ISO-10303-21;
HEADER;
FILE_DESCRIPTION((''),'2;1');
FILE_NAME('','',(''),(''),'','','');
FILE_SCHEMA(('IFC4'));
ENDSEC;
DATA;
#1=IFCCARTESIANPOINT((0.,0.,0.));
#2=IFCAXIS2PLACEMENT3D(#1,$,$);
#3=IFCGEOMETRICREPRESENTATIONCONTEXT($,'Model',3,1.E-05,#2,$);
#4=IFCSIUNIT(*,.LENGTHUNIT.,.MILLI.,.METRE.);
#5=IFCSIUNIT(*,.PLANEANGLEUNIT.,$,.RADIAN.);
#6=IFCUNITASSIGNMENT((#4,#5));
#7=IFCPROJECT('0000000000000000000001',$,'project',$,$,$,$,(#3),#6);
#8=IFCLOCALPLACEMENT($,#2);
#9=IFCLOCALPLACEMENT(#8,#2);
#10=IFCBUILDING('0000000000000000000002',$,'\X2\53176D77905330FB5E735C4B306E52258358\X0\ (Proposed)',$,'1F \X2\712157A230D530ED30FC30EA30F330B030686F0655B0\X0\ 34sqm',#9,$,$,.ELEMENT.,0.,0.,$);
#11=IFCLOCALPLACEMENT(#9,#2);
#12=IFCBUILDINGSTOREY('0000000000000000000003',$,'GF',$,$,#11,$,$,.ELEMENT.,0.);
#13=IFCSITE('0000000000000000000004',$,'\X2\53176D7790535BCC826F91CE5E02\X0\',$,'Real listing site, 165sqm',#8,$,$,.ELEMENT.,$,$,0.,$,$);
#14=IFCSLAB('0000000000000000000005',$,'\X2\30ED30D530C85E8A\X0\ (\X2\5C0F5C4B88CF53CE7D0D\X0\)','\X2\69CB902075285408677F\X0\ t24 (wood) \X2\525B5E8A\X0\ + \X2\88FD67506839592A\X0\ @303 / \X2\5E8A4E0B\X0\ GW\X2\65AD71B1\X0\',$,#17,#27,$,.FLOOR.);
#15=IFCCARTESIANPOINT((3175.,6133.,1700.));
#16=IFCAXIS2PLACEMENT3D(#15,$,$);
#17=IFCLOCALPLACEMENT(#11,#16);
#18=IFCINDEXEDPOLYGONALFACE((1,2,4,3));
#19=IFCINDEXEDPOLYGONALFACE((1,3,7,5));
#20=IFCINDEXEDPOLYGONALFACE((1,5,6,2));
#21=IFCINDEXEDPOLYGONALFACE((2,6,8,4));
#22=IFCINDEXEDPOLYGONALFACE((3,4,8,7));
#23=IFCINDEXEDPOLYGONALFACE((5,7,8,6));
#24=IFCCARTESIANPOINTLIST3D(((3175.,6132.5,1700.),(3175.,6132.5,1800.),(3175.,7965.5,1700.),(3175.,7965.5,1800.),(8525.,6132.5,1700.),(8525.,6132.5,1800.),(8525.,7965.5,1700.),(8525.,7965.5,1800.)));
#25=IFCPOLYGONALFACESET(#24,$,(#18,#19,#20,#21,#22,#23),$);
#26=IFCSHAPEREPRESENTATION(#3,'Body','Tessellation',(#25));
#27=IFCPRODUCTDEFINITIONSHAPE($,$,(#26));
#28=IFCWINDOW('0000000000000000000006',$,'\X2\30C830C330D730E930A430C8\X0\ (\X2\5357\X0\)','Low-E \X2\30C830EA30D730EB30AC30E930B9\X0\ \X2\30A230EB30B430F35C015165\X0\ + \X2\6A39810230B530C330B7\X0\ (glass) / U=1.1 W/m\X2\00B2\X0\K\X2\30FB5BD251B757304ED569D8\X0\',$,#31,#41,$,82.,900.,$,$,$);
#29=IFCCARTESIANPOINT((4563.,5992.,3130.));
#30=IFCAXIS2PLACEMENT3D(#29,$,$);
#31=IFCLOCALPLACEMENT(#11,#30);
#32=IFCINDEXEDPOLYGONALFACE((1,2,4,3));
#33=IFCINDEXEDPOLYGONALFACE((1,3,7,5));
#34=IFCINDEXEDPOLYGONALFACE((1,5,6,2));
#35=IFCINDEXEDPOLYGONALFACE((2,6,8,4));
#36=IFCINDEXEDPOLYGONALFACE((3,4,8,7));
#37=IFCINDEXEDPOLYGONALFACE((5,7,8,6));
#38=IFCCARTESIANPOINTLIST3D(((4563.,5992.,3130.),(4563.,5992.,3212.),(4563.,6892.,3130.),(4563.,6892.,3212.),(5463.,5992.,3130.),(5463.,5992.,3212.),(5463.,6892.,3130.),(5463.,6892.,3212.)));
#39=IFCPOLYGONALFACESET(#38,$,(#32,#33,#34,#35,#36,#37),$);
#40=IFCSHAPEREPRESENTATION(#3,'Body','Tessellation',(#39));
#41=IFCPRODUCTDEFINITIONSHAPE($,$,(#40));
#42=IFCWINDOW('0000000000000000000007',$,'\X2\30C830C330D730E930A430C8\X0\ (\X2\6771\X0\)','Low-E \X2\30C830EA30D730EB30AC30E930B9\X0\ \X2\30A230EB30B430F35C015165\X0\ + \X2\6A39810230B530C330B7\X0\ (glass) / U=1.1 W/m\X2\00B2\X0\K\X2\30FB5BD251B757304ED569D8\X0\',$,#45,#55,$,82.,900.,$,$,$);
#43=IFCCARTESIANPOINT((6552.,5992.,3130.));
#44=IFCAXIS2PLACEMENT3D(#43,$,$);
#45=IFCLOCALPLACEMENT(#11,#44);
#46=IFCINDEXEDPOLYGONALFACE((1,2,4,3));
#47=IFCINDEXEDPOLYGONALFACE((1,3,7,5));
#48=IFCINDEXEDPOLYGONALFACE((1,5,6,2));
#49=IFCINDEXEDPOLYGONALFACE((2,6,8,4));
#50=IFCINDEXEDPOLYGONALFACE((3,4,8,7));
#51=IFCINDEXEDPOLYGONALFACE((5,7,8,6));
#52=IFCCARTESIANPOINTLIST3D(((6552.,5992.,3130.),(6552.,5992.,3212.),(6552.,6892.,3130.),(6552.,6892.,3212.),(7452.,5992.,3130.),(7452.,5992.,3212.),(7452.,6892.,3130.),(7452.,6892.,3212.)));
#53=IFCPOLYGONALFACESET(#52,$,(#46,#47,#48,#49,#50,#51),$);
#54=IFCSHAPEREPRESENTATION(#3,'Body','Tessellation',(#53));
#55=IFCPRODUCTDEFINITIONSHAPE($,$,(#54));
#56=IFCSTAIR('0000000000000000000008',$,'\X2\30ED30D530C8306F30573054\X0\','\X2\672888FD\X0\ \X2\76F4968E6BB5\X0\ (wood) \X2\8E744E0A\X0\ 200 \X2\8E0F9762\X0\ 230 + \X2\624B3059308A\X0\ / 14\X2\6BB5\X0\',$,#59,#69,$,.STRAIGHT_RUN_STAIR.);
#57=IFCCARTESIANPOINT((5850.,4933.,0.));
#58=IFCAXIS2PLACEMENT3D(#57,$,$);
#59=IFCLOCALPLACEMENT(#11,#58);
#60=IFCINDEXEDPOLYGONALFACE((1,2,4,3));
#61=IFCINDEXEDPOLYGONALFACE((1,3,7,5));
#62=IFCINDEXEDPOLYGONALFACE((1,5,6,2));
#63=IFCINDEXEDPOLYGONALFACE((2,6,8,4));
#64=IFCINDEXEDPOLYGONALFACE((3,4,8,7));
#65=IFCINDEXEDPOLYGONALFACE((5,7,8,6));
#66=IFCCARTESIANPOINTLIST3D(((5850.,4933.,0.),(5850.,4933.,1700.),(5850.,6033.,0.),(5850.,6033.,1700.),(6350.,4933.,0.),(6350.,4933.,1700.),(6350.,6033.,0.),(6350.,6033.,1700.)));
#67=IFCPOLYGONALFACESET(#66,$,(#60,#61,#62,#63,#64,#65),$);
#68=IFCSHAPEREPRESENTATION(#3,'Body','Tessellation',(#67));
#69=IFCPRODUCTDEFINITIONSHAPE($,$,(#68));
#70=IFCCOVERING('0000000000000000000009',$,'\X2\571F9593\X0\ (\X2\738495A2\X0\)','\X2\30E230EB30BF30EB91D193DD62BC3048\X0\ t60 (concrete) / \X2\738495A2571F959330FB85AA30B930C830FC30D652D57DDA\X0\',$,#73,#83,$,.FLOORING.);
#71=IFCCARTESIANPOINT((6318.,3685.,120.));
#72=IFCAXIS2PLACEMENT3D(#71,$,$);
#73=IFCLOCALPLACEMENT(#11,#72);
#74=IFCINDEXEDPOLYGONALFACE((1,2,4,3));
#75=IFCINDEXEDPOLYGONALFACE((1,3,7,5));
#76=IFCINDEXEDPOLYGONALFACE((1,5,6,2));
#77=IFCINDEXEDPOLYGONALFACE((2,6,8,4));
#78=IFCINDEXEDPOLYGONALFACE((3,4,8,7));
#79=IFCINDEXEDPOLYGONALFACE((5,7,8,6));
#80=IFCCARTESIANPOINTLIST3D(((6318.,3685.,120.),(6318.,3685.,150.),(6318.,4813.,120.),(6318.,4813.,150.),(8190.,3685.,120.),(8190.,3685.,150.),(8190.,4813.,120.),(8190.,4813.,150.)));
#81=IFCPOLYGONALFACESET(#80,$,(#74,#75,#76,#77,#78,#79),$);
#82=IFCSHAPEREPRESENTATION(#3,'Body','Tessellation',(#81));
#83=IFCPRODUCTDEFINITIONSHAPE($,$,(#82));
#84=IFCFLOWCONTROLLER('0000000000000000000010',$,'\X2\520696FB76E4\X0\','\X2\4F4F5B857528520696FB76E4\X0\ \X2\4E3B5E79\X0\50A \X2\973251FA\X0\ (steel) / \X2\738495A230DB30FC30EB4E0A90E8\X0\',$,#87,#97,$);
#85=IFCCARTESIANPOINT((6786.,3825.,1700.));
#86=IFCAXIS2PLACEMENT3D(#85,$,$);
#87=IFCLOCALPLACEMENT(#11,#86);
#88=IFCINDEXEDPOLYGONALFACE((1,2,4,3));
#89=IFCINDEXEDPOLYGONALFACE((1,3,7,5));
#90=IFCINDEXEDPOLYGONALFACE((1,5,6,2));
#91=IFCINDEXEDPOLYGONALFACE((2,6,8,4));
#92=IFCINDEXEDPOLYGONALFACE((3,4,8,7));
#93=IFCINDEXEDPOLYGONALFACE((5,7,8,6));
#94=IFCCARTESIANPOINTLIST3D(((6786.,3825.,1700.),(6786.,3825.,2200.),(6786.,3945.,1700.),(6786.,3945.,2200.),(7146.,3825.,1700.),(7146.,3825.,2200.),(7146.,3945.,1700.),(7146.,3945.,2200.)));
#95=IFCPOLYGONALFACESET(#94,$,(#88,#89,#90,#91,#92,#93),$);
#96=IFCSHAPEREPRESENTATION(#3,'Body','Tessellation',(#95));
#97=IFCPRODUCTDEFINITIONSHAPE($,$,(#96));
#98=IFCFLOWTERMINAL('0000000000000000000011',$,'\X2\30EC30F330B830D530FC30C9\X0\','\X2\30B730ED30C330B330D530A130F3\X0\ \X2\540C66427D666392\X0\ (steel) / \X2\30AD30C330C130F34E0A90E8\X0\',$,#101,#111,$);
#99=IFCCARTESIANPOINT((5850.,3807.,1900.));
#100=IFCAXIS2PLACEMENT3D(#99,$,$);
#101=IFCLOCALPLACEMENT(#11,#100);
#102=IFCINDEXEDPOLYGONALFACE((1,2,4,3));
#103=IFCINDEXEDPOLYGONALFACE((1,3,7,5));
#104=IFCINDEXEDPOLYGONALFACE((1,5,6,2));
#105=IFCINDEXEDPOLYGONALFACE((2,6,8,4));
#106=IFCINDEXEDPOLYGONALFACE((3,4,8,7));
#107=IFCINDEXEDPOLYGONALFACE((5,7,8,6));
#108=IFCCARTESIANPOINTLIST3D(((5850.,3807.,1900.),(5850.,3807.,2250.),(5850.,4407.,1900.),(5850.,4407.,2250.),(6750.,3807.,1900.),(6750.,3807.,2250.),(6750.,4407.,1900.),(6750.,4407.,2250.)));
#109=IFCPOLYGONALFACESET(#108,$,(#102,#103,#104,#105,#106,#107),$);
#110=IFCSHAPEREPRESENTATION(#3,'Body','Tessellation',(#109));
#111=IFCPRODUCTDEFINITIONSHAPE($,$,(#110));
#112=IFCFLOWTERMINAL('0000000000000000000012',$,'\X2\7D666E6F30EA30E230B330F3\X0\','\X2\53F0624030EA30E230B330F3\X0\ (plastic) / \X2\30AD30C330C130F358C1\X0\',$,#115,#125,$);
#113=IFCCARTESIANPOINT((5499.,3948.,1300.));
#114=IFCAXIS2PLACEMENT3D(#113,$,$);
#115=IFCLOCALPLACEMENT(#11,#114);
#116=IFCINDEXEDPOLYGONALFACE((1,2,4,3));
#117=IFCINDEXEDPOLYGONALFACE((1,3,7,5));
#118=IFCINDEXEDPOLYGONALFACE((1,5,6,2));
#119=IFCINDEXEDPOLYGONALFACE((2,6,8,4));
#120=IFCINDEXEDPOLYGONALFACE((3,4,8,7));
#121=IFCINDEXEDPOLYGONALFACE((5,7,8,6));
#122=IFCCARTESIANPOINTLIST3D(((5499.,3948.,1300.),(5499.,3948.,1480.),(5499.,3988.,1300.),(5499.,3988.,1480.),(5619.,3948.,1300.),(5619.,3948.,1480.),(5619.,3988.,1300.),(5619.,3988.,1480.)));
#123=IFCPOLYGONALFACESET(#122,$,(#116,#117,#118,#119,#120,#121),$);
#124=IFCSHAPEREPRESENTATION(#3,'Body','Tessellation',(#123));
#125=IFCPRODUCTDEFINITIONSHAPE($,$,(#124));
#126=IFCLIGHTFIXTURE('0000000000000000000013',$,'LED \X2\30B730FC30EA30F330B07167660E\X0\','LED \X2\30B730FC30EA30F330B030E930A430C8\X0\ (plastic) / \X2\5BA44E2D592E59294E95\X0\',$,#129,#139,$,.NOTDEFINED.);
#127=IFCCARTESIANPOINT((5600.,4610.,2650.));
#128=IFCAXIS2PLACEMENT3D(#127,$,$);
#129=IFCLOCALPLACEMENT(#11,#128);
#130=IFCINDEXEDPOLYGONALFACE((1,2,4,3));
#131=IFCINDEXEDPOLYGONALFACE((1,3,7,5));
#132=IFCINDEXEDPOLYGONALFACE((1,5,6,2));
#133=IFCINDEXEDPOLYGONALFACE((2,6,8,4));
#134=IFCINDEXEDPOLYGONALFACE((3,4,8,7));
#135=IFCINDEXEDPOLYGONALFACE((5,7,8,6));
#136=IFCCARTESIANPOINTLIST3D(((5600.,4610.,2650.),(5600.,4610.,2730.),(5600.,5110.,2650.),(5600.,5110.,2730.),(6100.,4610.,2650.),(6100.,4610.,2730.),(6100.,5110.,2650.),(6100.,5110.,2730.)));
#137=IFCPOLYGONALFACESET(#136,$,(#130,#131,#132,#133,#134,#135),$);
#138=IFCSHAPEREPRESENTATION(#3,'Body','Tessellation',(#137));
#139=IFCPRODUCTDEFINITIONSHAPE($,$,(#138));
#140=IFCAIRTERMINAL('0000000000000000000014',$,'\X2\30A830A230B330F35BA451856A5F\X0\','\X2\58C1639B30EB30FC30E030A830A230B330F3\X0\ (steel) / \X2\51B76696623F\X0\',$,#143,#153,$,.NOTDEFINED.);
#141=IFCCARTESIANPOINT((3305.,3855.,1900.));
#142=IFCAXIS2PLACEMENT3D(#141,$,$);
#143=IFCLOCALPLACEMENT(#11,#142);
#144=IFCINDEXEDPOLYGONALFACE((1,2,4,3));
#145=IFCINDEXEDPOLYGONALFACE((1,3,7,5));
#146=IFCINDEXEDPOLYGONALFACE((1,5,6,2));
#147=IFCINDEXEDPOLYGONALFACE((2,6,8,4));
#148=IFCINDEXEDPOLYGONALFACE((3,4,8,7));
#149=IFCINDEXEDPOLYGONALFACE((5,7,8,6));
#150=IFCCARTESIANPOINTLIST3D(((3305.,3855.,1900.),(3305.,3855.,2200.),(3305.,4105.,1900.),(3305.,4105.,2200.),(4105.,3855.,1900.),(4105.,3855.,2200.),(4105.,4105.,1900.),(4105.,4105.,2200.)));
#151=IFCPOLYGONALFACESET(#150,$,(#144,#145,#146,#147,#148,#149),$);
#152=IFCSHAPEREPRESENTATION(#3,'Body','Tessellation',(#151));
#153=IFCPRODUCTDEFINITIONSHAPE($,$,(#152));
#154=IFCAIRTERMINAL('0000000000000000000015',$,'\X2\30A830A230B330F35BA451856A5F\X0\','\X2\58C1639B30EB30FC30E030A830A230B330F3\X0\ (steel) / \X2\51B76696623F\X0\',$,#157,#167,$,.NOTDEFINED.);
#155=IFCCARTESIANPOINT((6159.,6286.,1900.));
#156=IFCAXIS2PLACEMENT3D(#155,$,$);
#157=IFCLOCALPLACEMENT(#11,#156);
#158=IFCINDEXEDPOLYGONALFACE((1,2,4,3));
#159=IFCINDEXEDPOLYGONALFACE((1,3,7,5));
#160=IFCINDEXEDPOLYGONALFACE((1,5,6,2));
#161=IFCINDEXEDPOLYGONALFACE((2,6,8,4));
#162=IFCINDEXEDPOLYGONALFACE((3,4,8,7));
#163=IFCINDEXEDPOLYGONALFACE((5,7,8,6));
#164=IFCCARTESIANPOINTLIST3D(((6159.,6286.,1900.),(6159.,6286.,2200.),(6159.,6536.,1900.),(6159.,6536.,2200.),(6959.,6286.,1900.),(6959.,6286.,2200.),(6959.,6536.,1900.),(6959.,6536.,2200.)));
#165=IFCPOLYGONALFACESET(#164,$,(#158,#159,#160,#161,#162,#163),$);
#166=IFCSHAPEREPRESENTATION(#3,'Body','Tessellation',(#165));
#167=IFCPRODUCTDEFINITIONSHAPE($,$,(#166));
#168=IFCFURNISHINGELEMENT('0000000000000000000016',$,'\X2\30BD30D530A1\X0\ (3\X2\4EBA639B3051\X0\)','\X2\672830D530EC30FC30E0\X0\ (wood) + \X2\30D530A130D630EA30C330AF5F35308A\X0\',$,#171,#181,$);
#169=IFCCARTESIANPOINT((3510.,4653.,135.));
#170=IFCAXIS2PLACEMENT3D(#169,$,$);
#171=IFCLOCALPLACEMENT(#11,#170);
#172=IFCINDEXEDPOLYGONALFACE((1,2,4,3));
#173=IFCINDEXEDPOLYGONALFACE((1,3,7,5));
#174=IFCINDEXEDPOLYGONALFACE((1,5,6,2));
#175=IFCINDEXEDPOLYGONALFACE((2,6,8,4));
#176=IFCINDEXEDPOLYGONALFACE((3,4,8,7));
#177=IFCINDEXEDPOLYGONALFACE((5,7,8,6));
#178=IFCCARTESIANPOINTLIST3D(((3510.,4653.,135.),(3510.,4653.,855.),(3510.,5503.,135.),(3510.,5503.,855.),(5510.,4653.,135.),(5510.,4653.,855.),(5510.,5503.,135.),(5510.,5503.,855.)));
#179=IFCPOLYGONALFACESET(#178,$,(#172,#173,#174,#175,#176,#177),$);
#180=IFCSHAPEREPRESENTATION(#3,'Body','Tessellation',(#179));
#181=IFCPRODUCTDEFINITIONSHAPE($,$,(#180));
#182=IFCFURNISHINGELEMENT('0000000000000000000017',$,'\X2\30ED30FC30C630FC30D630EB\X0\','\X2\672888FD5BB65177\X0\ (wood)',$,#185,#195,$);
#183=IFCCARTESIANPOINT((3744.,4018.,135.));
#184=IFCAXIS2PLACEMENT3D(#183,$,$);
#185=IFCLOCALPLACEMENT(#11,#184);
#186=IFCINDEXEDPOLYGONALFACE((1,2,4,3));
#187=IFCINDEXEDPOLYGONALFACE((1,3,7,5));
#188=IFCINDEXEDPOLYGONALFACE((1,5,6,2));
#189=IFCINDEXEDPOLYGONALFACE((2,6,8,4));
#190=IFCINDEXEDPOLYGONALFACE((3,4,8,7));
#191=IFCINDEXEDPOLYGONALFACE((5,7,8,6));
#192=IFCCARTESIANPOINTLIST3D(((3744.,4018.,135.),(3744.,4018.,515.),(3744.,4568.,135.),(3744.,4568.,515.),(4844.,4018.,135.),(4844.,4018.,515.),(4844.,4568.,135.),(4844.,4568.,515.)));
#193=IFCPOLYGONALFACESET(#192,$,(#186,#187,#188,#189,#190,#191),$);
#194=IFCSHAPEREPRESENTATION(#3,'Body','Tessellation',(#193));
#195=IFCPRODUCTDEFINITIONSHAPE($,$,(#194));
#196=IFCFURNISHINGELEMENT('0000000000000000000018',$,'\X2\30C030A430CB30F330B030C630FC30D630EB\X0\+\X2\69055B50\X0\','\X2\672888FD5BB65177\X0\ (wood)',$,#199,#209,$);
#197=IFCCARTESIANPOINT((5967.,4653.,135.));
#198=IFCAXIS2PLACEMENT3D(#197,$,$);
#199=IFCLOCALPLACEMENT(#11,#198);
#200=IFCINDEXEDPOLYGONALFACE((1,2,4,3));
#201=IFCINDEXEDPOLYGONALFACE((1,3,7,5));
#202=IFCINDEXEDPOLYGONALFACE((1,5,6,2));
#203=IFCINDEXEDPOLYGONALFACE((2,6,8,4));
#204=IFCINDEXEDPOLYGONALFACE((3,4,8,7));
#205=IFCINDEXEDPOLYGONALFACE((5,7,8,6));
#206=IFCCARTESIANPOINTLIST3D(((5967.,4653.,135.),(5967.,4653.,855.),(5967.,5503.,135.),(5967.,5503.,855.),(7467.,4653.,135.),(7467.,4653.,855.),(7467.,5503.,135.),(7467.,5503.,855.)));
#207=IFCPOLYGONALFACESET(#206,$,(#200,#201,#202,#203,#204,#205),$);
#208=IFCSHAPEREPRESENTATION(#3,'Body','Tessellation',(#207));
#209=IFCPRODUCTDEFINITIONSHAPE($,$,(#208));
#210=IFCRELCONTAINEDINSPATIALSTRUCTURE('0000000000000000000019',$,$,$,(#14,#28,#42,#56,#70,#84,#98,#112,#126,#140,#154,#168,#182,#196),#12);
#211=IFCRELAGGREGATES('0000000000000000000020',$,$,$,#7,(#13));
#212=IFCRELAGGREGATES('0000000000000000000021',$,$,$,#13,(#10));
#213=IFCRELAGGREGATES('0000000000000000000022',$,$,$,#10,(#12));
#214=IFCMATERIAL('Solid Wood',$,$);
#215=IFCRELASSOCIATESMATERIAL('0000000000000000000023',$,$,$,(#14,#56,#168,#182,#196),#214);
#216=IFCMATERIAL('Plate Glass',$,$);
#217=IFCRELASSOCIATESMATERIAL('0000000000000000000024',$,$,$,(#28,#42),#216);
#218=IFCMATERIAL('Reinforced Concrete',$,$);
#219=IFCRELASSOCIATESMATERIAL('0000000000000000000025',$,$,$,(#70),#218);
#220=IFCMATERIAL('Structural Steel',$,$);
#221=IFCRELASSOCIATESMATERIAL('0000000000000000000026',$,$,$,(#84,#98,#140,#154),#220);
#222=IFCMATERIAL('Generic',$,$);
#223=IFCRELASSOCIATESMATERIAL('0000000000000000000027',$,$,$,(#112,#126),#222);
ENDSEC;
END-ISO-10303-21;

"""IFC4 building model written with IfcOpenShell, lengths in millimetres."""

from ifc_helpers import new_model, si_unit, frame, frame_2d, origin, place, context, project, spatial, rectangle, extrude, material, element, save


model = new_model("IFC4")

# Units and contexts
model_context = context("Model", 3, precision=1e-05, world=origin())
ifc_project = project(units=[si_unit("LENGTHUNIT", "METRE", prefix="MILLI"), si_unit("PLANEANGLEUNIT", "RADIAN")], contexts=[model_context])

# Site, building, storey
site_placement = place(None, origin())
site = spatial("IfcSite", under=ifc_project, at=site_placement, Name="北海道富良野市", ObjectType="Real listing site, 165sqm", CompositionType="ELEMENT", RefElevation=0.0)
building_placement = place(site_placement, origin())
building = spatial("IfcBuilding", under=site, at=building_placement, Name="北海道・平屋の別荘 (Proposed)", ObjectType="1F 無垢フローリングと漆喰 34sqm", CompositionType="ELEMENT", ElevationOfRefHeight=0.0, ElevationOfTerrain=0.0)
storey_placement = place(building_placement, origin())
storey = spatial("IfcBuildingStorey", under=building, at=storey_placement, Name="GF", CompositionType="ELEMENT", Elevation=0.0)

# Shared definitions
ifc_material_1 = material(Name="Solid Wood")

# Slab
slab_placement = place(storey_placement, frame((3175.0, 6133.0, 1700.0)))
element("IfcSlab", 1, at=slab_placement, inside=storey, material=ifc_material_1, Name="ロフト床 (小屋裏収納)", Description="構造用合板 t24 (wood) 剛床 + 製材根太 @303 / 床下 GW断熱", PredefinedType="FLOOR", context=model_context, shape_type="SweptSolid", body=[
    extrude(rectangle(XDim=5350.0, YDim=1833.0, at=frame_2d((2675.0, 916.0))), frame((3175.0, 6133.0, 1700.0)), (0.0, 0.0, 1.0), 100.0),
])

# Windows
ifc_material_2 = material(Name="Plate Glass")
window_1_placement = place(storey_placement, frame((4563.0, 5992.0, 3130.0)))
element("IfcWindow", 2, at=window_1_placement, inside=storey, material=ifc_material_2, Name="トップライト (南)", Description="Low-E トリプルガラス アルゴン封入 + 樹脂サッシ (glass) / U=1.1 W/m²K・寒冷地仕様", OverallHeight=82.0, OverallWidth=900.0, context=model_context, shape_type="SweptSolid", body=[
    extrude(rectangle(XDim=900.0, YDim=900.0, at=frame_2d((450.0, 450.0))), frame((4563.0, 5992.0, 3130.0)), (0.0, 0.0, 1.0), 82.0),
])
window_2_placement = place(storey_placement, frame((6552.0, 5992.0, 3130.0)))
element("IfcWindow", 3, at=window_2_placement, inside=storey, material=ifc_material_2, Name="トップライト (東)", Description="Low-E トリプルガラス アルゴン封入 + 樹脂サッシ (glass) / U=1.1 W/m²K・寒冷地仕様", OverallHeight=82.0, OverallWidth=900.0, context=model_context, shape_type="SweptSolid", body=[
    extrude(rectangle(XDim=900.0, YDim=900.0, at=frame_2d((450.0, 450.0))), frame((6552.0, 5992.0, 3130.0)), (0.0, 0.0, 1.0), 82.0),
])

# Stair
stair_placement = place(storey_placement, frame((5850.0, 4933.0, 0.0)))
element("IfcStair", 4, at=stair_placement, inside=storey, material=ifc_material_1, Name="ロフトはしご", Description="木製 直階段 (wood) 蹴上 200 踏面 230 + 手すり / 14段", PredefinedType="STRAIGHT_RUN_STAIR", context=model_context, shape_type="SweptSolid", body=[
    extrude(rectangle(XDim=500.0, YDim=1100.0, at=frame_2d((250.0, 550.0))), frame((5850.0, 4933.0, 0.0)), (0.0, 0.0, 1.0), 1700.0),
])

# Covering
ifc_material_3 = material(Name="Reinforced Concrete")
covering_placement = place(storey_placement, frame((6318.0, 3685.0, 120.0)))
element("IfcCovering", 5, at=covering_placement, inside=storey, material=ifc_material_3, Name="土間 (玄関)", Description="モルタル金鏝押え t60 (concrete) / 玄関土間・薪ストーブ動線", PredefinedType="FLOORING", context=model_context, shape_type="SweptSolid", body=[
    extrude(rectangle(XDim=1872.0, YDim=1128.0, at=frame_2d((936.0, 564.0))), frame((6318.0, 3685.0, 120.0)), (0.0, 0.0, 1.0), 30.0),
])

# Flow controller
ifc_material_4 = material(Name="Structural Steel")
flow_controller_placement = place(storey_placement, frame((6786.0, 3825.0, 1700.0)))
element("IfcFlowController", 6, at=flow_controller_placement, inside=storey, material=ifc_material_4, Name="分電盤", Description="住宅用分電盤 主幹50A 露出 (steel) / 玄関ホール上部", context=model_context, shape_type="SweptSolid", body=[
    extrude(rectangle(XDim=360.0, YDim=120.0, at=frame_2d((180.0, 60.0))), frame((6786.0, 3825.0, 1700.0)), (0.0, 0.0, 1.0), 500.0),
])

# Flow terminals
flow_terminal_1_placement = place(storey_placement, frame((5850.0, 3807.0, 1900.0)))
element("IfcFlowTerminal", 7, at=flow_terminal_1_placement, inside=storey, material=ifc_material_4, Name="レンジフード", Description="シロッコファン 同時給排 (steel) / キッチン上部", context=model_context, shape_type="SweptSolid", body=[
    extrude(rectangle(XDim=900.0, YDim=600.0, at=frame_2d((450.0, 300.0))), frame((5850.0, 3807.0, 1900.0)), (0.0, 0.0, 1.0), 350.0),
])
ifc_material_5 = material(Name="Generic")
flow_terminal_2_placement = place(storey_placement, frame((5499.0, 3948.0, 1300.0)))
element("IfcFlowTerminal", 8, at=flow_terminal_2_placement, inside=storey, material=ifc_material_5, Name="給湯リモコン", Description="台所リモコン (plastic) / キッチン壁", context=model_context, shape_type="SweptSolid", body=[
    extrude(rectangle(XDim=120.0, YDim=40.0, at=frame_2d((60.0, 20.0))), frame((5499.0, 3948.0, 1300.0)), (0.0, 0.0, 1.0), 180.0),
])

# Light fixture
light_fixture_placement = place(storey_placement, frame((5600.0, 4610.0, 2650.0)))
element("IfcLightFixture", 9, at=light_fixture_placement, inside=storey, material=ifc_material_5, Name="LED シーリング照明", Description="LED シーリングライト (plastic) / 室中央天井", PredefinedType="NOTDEFINED", context=model_context, shape_type="SweptSolid", body=[
    extrude(rectangle(XDim=500.0, YDim=500.0, at=frame_2d((250.0, 250.0))), frame((5600.0, 4610.0, 2650.0)), (0.0, 0.0, 1.0), 80.0),
])

# Air terminals
air_terminal_1_placement = place(storey_placement, frame((3305.0, 3855.0, 1900.0)))
element("IfcAirTerminal", 10, at=air_terminal_1_placement, inside=storey, material=ifc_material_4, Name="エアコン室内機", Description="壁掛ルームエアコン (steel) / 冷暖房", PredefinedType="NOTDEFINED", context=model_context, shape_type="SweptSolid", body=[
    extrude(rectangle(XDim=800.0, YDim=250.0, at=frame_2d((400.0, 125.0))), frame((3305.0, 3855.0, 1900.0)), (0.0, 0.0, 1.0), 300.0),
])
air_terminal_2_placement = place(storey_placement, frame((6159.0, 6286.0, 1900.0)))
element("IfcAirTerminal", 11, at=air_terminal_2_placement, inside=storey, material=ifc_material_4, Name="エアコン室内機", Description="壁掛ルームエアコン (steel) / 冷暖房", PredefinedType="NOTDEFINED", context=model_context, shape_type="SweptSolid", body=[
    extrude(rectangle(XDim=800.0, YDim=250.0, at=frame_2d((400.0, 125.0))), frame((6159.0, 6286.0, 1900.0)), (0.0, 0.0, 1.0), 300.0),
])

# Furnishing elements
furnishing_1_placement = place(storey_placement, frame((3510.0, 4653.0, 135.0)))
element("IfcFurnishingElement", 12, at=furnishing_1_placement, inside=storey, material=ifc_material_1, Name="ソファ (3人掛け)", Description="木フレーム (wood) + ファブリック張り", context=model_context, shape_type="SweptSolid", body=[
    extrude(rectangle(XDim=2000.0, YDim=850.0, at=frame_2d((1000.0, 425.0))), frame((3510.0, 4653.0, 135.0)), (0.0, 0.0, 1.0), 720.0),
])
furnishing_2_placement = place(storey_placement, frame((3744.0, 4018.0, 135.0)))
element("IfcFurnishingElement", 13, at=furnishing_2_placement, inside=storey, material=ifc_material_1, Name="ローテーブル", Description="木製家具 (wood)", context=model_context, shape_type="SweptSolid", body=[
    extrude(rectangle(XDim=1100.0, YDim=550.0, at=frame_2d((550.0, 275.0))), frame((3744.0, 4018.0, 135.0)), (0.0, 0.0, 1.0), 380.0),
])
furnishing_3_placement = place(storey_placement, frame((5967.0, 4653.0, 135.0)))
element("IfcFurnishingElement", 14, at=furnishing_3_placement, inside=storey, material=ifc_material_1, Name="ダイニングテーブル+椅子", Description="木製家具 (wood)", context=model_context, shape_type="SweptSolid", body=[
    extrude(rectangle(XDim=1500.0, YDim=850.0, at=frame_2d((750.0, 425.0))), frame((5967.0, 4653.0, 135.0)), (0.0, 0.0, 1.0), 720.0),
])

save(model, "model.ifc")
